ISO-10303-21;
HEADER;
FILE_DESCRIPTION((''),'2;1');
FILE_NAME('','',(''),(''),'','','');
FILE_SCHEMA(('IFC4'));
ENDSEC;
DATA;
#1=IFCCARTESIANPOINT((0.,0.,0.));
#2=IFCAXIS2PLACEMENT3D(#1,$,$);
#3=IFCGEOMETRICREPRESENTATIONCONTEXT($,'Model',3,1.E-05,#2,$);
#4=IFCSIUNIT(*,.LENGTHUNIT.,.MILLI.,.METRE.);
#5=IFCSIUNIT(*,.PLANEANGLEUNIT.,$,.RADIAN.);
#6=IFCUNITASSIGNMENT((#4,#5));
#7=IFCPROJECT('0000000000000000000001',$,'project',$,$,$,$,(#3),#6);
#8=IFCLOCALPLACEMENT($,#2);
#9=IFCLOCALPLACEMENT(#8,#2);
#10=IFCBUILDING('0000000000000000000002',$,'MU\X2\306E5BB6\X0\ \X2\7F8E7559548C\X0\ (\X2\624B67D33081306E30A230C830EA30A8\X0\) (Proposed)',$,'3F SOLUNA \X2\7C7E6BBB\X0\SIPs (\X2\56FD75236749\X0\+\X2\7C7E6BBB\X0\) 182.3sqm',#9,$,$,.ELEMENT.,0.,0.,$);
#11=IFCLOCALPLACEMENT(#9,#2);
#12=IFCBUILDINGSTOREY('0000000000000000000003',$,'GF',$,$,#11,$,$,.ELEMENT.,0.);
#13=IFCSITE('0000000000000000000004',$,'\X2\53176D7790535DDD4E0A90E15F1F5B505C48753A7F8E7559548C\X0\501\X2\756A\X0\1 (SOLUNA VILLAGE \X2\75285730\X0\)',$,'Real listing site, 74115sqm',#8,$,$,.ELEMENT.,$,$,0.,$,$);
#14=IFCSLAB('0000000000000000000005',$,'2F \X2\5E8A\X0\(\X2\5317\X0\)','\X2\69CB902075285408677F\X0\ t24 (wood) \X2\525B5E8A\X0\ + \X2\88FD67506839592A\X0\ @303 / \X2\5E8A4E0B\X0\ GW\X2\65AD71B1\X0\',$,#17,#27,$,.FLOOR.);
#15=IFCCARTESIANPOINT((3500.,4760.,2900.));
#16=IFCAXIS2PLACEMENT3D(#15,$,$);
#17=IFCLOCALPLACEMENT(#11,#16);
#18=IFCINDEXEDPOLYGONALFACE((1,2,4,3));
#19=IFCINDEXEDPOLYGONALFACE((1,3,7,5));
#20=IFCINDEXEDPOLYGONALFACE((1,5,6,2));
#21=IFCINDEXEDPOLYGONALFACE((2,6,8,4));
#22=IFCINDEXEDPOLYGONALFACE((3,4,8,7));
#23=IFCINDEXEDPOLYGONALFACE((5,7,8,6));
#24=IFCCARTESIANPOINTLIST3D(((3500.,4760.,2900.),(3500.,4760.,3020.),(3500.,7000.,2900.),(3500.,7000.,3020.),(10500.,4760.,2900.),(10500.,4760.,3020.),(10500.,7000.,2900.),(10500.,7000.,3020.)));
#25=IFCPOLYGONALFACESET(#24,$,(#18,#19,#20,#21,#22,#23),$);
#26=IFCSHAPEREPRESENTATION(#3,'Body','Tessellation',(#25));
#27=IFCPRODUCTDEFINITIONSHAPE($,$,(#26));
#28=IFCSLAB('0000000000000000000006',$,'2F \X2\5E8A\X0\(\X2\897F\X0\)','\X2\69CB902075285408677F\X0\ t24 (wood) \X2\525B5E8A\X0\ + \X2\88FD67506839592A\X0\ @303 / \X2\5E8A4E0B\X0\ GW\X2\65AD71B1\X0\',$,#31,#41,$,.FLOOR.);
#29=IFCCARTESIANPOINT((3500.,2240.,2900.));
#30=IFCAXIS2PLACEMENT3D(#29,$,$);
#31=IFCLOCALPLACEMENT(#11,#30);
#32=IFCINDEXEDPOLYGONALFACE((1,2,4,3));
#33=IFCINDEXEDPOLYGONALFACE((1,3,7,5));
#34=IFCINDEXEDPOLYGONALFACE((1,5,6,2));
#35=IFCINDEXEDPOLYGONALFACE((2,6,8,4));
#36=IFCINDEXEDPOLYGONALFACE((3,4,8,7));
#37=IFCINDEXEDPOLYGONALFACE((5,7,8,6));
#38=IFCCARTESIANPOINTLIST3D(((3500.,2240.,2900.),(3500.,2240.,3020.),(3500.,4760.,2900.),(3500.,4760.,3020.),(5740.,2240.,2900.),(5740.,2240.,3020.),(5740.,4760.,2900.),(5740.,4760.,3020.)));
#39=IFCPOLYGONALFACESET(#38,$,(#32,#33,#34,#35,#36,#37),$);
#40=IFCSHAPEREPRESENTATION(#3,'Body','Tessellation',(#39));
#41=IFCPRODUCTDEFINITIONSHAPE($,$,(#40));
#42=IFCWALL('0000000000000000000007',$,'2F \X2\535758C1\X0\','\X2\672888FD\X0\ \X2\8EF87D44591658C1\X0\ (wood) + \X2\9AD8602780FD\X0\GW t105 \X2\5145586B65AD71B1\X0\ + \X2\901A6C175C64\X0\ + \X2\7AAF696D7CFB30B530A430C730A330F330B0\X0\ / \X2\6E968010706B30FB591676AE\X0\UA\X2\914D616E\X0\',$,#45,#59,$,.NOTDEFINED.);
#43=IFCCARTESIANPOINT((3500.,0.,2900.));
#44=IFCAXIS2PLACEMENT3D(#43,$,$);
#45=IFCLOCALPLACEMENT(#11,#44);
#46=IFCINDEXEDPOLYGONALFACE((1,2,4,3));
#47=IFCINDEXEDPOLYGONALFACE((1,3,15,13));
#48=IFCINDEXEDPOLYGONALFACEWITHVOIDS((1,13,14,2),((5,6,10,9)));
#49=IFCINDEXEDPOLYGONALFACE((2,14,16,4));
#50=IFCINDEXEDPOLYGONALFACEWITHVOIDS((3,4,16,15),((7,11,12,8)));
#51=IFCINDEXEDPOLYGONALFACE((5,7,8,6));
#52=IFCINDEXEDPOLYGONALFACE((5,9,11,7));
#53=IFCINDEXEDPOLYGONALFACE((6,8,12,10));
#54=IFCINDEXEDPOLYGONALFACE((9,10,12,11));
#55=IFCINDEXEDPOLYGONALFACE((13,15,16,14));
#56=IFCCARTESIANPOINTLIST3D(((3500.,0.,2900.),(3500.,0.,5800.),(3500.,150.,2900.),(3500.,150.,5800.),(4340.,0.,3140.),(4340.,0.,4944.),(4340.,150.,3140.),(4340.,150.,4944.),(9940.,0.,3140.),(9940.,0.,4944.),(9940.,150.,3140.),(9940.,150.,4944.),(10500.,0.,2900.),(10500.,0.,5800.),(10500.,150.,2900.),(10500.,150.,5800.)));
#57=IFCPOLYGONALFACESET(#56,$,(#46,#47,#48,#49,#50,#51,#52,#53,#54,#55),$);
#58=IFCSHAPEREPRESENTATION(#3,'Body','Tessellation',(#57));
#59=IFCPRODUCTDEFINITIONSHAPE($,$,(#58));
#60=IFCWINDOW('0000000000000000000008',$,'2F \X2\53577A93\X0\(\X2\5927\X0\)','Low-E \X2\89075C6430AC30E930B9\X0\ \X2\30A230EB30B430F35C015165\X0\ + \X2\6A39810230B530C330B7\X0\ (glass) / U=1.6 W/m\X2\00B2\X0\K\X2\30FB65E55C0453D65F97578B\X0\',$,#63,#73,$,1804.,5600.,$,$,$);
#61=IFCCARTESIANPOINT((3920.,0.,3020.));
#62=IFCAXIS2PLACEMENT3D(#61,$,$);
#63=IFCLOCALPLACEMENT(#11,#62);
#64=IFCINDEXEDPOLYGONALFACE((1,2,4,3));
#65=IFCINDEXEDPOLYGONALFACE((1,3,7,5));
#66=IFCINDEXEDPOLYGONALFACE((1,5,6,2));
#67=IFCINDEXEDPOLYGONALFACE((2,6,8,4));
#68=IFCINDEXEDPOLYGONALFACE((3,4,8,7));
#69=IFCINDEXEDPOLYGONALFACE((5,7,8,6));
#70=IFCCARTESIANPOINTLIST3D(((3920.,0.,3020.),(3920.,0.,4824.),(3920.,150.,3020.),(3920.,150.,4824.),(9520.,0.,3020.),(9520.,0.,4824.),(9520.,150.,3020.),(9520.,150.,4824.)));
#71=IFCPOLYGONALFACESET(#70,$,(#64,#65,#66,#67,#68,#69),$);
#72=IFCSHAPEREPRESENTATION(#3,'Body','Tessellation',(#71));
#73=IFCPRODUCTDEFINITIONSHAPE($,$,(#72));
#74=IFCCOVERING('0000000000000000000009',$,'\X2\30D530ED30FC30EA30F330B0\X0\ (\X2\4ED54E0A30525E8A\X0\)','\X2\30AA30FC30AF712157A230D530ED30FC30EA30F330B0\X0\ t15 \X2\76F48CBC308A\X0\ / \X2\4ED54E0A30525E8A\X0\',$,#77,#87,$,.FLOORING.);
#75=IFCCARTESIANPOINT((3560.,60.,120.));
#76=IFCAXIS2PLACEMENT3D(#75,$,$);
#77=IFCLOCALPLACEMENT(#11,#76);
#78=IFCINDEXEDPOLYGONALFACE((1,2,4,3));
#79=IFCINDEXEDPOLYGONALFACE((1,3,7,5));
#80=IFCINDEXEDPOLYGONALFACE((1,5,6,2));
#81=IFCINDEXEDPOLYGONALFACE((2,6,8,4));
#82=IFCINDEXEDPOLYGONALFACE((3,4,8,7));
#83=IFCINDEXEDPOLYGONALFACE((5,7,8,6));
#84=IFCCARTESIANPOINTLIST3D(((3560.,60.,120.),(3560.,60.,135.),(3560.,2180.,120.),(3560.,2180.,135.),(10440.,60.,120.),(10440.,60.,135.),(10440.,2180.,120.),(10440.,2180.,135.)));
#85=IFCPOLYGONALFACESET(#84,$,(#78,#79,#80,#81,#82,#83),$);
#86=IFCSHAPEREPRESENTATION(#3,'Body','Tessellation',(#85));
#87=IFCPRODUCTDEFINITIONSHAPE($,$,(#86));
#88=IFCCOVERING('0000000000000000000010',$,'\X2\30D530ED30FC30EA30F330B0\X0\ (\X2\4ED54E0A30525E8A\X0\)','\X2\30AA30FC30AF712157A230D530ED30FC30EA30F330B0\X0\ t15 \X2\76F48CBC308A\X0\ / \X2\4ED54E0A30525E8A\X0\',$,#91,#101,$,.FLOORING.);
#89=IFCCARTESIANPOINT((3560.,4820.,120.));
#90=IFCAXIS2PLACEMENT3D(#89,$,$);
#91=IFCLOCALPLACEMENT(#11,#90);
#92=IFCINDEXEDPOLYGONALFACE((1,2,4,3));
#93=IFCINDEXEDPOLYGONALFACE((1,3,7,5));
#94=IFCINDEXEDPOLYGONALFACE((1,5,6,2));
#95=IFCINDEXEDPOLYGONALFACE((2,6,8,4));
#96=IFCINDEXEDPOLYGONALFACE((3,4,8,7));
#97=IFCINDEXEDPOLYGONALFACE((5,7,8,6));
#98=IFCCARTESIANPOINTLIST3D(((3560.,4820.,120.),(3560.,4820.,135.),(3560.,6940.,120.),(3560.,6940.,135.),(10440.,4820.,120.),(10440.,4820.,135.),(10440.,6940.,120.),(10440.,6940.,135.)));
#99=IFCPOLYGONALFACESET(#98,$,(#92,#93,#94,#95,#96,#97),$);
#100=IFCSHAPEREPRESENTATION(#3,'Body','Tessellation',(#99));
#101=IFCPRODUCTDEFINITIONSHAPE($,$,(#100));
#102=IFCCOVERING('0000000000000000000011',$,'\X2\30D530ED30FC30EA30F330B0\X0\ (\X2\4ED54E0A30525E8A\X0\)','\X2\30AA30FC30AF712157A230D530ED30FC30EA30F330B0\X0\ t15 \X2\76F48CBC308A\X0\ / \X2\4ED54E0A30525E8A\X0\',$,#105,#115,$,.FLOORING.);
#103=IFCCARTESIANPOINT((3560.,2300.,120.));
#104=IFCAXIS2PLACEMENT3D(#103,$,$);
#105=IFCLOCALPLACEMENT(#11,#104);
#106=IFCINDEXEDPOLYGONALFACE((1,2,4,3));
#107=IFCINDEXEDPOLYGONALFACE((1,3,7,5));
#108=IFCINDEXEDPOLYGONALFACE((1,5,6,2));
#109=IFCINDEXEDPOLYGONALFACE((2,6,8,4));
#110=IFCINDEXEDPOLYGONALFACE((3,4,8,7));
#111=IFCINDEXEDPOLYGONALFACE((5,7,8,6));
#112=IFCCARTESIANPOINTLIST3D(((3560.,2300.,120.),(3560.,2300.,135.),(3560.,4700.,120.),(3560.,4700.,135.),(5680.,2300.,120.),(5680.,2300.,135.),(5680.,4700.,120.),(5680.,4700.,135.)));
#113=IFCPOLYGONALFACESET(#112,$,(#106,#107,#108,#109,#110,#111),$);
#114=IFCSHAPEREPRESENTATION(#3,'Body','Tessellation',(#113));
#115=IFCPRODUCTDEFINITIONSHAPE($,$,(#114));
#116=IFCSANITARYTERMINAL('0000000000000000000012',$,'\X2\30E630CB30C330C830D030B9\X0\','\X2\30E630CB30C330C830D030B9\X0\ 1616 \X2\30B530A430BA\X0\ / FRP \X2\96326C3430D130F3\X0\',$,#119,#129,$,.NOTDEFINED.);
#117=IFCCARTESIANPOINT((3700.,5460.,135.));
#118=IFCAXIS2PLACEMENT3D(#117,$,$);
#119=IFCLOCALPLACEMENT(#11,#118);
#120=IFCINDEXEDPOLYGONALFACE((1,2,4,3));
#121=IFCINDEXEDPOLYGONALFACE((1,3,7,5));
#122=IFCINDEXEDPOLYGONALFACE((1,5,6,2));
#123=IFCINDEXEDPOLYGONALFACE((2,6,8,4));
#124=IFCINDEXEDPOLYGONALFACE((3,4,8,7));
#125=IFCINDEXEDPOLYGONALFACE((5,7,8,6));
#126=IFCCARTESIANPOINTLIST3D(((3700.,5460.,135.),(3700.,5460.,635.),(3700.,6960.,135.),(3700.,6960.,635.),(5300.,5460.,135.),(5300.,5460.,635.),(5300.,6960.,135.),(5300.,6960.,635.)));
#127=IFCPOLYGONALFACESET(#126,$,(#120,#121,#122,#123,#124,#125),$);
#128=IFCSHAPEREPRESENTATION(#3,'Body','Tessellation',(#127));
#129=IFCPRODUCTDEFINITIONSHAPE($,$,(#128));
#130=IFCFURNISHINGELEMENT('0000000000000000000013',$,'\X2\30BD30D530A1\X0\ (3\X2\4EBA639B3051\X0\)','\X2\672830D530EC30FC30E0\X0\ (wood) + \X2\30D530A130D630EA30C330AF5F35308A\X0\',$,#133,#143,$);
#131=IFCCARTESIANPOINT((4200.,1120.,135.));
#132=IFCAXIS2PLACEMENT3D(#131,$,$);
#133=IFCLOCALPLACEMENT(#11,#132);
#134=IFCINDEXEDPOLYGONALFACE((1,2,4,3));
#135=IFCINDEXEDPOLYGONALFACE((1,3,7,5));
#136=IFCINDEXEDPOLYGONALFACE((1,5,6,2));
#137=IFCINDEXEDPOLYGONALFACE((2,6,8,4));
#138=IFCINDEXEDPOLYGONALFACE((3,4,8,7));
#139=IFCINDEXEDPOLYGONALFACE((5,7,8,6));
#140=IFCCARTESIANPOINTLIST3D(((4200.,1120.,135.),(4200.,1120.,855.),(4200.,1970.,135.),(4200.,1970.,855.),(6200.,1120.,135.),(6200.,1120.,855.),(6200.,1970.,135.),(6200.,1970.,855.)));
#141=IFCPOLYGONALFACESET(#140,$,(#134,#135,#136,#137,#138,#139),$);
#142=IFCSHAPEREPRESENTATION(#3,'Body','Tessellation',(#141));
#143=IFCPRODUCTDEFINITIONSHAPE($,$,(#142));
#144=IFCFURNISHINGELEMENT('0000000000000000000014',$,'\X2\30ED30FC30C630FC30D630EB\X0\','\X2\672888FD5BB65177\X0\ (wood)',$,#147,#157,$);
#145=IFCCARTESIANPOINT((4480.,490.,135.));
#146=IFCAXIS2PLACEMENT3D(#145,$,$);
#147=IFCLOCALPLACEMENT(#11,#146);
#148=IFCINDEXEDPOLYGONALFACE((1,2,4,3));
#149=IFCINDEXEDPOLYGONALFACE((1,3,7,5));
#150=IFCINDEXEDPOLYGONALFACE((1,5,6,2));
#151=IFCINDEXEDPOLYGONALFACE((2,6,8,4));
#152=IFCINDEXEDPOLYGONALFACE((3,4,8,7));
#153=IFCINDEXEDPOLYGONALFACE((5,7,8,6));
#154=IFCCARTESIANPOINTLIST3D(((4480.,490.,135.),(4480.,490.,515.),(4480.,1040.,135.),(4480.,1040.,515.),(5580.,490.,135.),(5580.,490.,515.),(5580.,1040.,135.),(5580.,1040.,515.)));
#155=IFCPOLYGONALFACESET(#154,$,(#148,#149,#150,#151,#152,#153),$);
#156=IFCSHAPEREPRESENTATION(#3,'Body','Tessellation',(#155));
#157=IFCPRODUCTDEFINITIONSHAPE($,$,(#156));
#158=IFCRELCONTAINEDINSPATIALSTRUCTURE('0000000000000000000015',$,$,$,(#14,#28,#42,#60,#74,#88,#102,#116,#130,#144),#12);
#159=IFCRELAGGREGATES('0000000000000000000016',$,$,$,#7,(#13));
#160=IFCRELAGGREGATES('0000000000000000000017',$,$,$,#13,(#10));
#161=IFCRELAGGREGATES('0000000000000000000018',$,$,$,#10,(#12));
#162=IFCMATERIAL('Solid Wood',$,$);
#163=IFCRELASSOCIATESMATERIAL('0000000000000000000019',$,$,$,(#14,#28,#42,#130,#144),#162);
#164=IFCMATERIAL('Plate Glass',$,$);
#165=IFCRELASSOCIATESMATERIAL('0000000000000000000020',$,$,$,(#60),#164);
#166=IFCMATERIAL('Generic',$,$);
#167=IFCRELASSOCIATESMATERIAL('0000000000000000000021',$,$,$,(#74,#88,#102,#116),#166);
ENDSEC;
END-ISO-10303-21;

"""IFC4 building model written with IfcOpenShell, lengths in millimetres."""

from ifc_helpers import new_model, si_unit, frame, frame_2d, origin, place, context, project, spatial, rectangle, extrude, material, element, fill, save


model = new_model("IFC4")

# Units and contexts
model_context = context("Model", 3, precision=1e-05, world=origin())
ifc_project = project(units=[si_unit("LENGTHUNIT", "METRE", prefix="MILLI"), si_unit("PLANEANGLEUNIT", "RADIAN")], contexts=[model_context])

# Site, building, storey
site_placement = place(None, origin())
site = spatial("IfcSite", under=ifc_project, at=site_placement, Name="北海道川上郡弟子屈町美留和501番1 (SOLUNA VILLAGE 用地)", ObjectType="Real listing site, 74115sqm", CompositionType="ELEMENT", RefElevation=0.0)
building_placement = place(site_placement, origin())
building = spatial("IfcBuilding", under=site, at=building_placement, Name="MUの家 美留和 (手染めのアトリエ) (Proposed)", ObjectType="3F SOLUNA 籾殻SIPs (国産杉+籾殻) 182.3sqm", CompositionType="ELEMENT", ElevationOfRefHeight=0.0, ElevationOfTerrain=0.0)
storey_placement = place(building_placement, origin())
storey = spatial("IfcBuildingStorey", under=building, at=storey_placement, Name="GF", CompositionType="ELEMENT", Elevation=0.0)

# Slabs
ifc_material_1 = material(Name="Solid Wood")
slab_1_placement = place(storey_placement, frame((3500.0, 4760.0, 2900.0)))
element("IfcSlab", 1, at=slab_1_placement, inside=storey, material=ifc_material_1, Name="2F 床(北)", Description="構造用合板 t24 (wood) 剛床 + 製材根太 @303 / 床下 GW断熱", PredefinedType="FLOOR", context=model_context, shape_type="SweptSolid", body=[
    extrude(rectangle(XDim=7000.0, YDim=2240.0, at=frame_2d((3500.0, 1120.0))), frame((3500.0, 4760.0, 2900.0)), (0.0, 0.0, 1.0), 120.0),
])
slab_2_placement = place(storey_placement, frame((3500.0, 2240.0, 2900.0)))
element("IfcSlab", 2, at=slab_2_placement, inside=storey, material=ifc_material_1, Name="2F 床(西)", Description="構造用合板 t24 (wood) 剛床 + 製材根太 @303 / 床下 GW断熱", PredefinedType="FLOOR", context=model_context, shape_type="SweptSolid", body=[
    extrude(rectangle(XDim=2240.0, YDim=2520.0, at=frame_2d((1120.0, 1260.0))), frame((3500.0, 2240.0, 2900.0)), (0.0, 0.0, 1.0), 120.0),
])

# Shared definitions
ifc_material_2 = material(Name="Plate Glass")

# Wall, opening, window
wall_1_placement = place(storey_placement, frame((3500.0, 0.0, 2900.0)))
wall_1 = element("IfcWall", 3, at=wall_1_placement, inside=storey, material=ifc_material_1, Name="2F 南壁", Description="木製 軸組外壁 (wood) + 高性能GW t105 充填断熱 + 通気層 + 窯業系サイディング / 準耐火・外皮UA配慮", PredefinedType="NOTDEFINED", context=model_context, shape_type="SweptSolid", body=[
    extrude(rectangle(XDim=7000.0, YDim=150.0, at=frame_2d((3500.0, 75.0))), frame((3500.0, 0.0, 2900.0)), (0.0, 0.0, 1.0), 2900.0),
])
opening_1_placement = place(storey_placement, frame((3920.0, 0.0, 3020.0)))
opening_1 = element("IfcOpeningElement", 4, at=opening_1_placement, cuts=wall_1, PredefinedType="NOTDEFINED", context=model_context, shape_type="SweptSolid", body=[
    extrude(rectangle(XDim=5600.0, YDim=150.0, at=frame_2d((2800.0, 75.0))), frame((3920.0, 0.0, 3020.0)), (0.0, 0.0, 1.0), 1804.0),
])
window_1_placement = place(storey_placement, frame((3920.0, 0.0, 3020.0)))
window_1 = element("IfcWindow", 5, at=window_1_placement, inside=storey, material=ifc_material_2, Name="2F 南窓(大)", Description="Low-E 複層ガラス アルゴン封入 + 樹脂サッシ (glass) / U=1.6 W/m²K・日射取得型", OverallHeight=1804.0, OverallWidth=5600.0, context=model_context, shape_type="SweptSolid", body=[
    extrude(rectangle(XDim=5600.0, YDim=150.0, at=frame_2d((2800.0, 75.0))), frame((3920.0, 0.0, 3020.0)), (0.0, 0.0, 1.0), 1804.0),
])
fill(opening_1, window_1)

# Coverings
ifc_material_3 = material(Name="Generic")
covering_1_placement = place(storey_placement, frame((3560.0, 60.0, 120.0)))
element("IfcCovering", 6, at=covering_1_placement, inside=storey, material=ifc_material_3, Name="フローリング (仕上げ床)", Description="オーク無垢フローリング t15 直貼り / 仕上げ床", PredefinedType="FLOORING", context=model_context, shape_type="SweptSolid", body=[
    extrude(rectangle(XDim=6880.0, YDim=2120.0, at=frame_2d((3440.0, 1060.0))), frame((3560.0, 60.0, 120.0)), (0.0, 0.0, 1.0), 15.0),
])
covering_2_placement = place(storey_placement, frame((3560.0, 4820.0, 120.0)))
element("IfcCovering", 7, at=covering_2_placement, inside=storey, material=ifc_material_3, Name="フローリング (仕上げ床)", Description="オーク無垢フローリング t15 直貼り / 仕上げ床", PredefinedType="FLOORING", context=model_context, shape_type="SweptSolid", body=[
    extrude(rectangle(XDim=6880.0, YDim=2120.0, at=frame_2d((3440.0, 1060.0))), frame((3560.0, 4820.0, 120.0)), (0.0, 0.0, 1.0), 15.0),
])
covering_3_placement = place(storey_placement, frame((3560.0, 2300.0, 120.0)))
element("IfcCovering", 8, at=covering_3_placement, inside=storey, material=ifc_material_3, Name="フローリング (仕上げ床)", Description="オーク無垢フローリング t15 直貼り / 仕上げ床", PredefinedType="FLOORING", context=model_context, shape_type="SweptSolid", body=[
    extrude(rectangle(XDim=2120.0, YDim=2400.0, at=frame_2d((1060.0, 1200.0))), frame((3560.0, 2300.0, 120.0)), (0.0, 0.0, 1.0), 15.0),
])

# Sanitary terminal
sanitary_terminal_placement = place(storey_placement, frame((3700.0, 5460.0, 135.0)))
element("IfcSanitaryTerminal", 9, at=sanitary_terminal_placement, inside=storey, material=ifc_material_3, Name="ユニットバス", Description="ユニットバス 1616 サイズ / FRP 防水パン", PredefinedType="NOTDEFINED", context=model_context, shape_type="SweptSolid", body=[
    extrude(rectangle(XDim=1600.0, YDim=1500.0, at=frame_2d((800.0, 750.0))), frame((3700.0, 5460.0, 135.0)), (0.0, 0.0, 1.0), 500.0),
])

# Furnishing elements
furnishing_1_placement = place(storey_placement, frame((4200.0, 1120.0, 135.0)))
element("IfcFurnishingElement", 10, at=furnishing_1_placement, inside=storey, material=ifc_material_1, Name="ソファ (3人掛け)", Description="木フレーム (wood) + ファブリック張り", context=model_context, shape_type="SweptSolid", body=[
    extrude(rectangle(XDim=2000.0, YDim=850.0, at=frame_2d((1000.0, 425.0))), frame((4200.0, 1120.0, 135.0)), (0.0, 0.0, 1.0), 720.0),
])
furnishing_2_placement = place(storey_placement, frame((4480.0, 490.0, 135.0)))
element("IfcFurnishingElement", 11, at=furnishing_2_placement, inside=storey, material=ifc_material_1, Name="ローテーブル", Description="木製家具 (wood)", context=model_context, shape_type="SweptSolid", body=[
    extrude(rectangle(XDim=1100.0, YDim=550.0, at=frame_2d((550.0, 275.0))), frame((4480.0, 490.0, 135.0)), (0.0, 0.0, 1.0), 380.0),
])

save(model, "model.ifc")
